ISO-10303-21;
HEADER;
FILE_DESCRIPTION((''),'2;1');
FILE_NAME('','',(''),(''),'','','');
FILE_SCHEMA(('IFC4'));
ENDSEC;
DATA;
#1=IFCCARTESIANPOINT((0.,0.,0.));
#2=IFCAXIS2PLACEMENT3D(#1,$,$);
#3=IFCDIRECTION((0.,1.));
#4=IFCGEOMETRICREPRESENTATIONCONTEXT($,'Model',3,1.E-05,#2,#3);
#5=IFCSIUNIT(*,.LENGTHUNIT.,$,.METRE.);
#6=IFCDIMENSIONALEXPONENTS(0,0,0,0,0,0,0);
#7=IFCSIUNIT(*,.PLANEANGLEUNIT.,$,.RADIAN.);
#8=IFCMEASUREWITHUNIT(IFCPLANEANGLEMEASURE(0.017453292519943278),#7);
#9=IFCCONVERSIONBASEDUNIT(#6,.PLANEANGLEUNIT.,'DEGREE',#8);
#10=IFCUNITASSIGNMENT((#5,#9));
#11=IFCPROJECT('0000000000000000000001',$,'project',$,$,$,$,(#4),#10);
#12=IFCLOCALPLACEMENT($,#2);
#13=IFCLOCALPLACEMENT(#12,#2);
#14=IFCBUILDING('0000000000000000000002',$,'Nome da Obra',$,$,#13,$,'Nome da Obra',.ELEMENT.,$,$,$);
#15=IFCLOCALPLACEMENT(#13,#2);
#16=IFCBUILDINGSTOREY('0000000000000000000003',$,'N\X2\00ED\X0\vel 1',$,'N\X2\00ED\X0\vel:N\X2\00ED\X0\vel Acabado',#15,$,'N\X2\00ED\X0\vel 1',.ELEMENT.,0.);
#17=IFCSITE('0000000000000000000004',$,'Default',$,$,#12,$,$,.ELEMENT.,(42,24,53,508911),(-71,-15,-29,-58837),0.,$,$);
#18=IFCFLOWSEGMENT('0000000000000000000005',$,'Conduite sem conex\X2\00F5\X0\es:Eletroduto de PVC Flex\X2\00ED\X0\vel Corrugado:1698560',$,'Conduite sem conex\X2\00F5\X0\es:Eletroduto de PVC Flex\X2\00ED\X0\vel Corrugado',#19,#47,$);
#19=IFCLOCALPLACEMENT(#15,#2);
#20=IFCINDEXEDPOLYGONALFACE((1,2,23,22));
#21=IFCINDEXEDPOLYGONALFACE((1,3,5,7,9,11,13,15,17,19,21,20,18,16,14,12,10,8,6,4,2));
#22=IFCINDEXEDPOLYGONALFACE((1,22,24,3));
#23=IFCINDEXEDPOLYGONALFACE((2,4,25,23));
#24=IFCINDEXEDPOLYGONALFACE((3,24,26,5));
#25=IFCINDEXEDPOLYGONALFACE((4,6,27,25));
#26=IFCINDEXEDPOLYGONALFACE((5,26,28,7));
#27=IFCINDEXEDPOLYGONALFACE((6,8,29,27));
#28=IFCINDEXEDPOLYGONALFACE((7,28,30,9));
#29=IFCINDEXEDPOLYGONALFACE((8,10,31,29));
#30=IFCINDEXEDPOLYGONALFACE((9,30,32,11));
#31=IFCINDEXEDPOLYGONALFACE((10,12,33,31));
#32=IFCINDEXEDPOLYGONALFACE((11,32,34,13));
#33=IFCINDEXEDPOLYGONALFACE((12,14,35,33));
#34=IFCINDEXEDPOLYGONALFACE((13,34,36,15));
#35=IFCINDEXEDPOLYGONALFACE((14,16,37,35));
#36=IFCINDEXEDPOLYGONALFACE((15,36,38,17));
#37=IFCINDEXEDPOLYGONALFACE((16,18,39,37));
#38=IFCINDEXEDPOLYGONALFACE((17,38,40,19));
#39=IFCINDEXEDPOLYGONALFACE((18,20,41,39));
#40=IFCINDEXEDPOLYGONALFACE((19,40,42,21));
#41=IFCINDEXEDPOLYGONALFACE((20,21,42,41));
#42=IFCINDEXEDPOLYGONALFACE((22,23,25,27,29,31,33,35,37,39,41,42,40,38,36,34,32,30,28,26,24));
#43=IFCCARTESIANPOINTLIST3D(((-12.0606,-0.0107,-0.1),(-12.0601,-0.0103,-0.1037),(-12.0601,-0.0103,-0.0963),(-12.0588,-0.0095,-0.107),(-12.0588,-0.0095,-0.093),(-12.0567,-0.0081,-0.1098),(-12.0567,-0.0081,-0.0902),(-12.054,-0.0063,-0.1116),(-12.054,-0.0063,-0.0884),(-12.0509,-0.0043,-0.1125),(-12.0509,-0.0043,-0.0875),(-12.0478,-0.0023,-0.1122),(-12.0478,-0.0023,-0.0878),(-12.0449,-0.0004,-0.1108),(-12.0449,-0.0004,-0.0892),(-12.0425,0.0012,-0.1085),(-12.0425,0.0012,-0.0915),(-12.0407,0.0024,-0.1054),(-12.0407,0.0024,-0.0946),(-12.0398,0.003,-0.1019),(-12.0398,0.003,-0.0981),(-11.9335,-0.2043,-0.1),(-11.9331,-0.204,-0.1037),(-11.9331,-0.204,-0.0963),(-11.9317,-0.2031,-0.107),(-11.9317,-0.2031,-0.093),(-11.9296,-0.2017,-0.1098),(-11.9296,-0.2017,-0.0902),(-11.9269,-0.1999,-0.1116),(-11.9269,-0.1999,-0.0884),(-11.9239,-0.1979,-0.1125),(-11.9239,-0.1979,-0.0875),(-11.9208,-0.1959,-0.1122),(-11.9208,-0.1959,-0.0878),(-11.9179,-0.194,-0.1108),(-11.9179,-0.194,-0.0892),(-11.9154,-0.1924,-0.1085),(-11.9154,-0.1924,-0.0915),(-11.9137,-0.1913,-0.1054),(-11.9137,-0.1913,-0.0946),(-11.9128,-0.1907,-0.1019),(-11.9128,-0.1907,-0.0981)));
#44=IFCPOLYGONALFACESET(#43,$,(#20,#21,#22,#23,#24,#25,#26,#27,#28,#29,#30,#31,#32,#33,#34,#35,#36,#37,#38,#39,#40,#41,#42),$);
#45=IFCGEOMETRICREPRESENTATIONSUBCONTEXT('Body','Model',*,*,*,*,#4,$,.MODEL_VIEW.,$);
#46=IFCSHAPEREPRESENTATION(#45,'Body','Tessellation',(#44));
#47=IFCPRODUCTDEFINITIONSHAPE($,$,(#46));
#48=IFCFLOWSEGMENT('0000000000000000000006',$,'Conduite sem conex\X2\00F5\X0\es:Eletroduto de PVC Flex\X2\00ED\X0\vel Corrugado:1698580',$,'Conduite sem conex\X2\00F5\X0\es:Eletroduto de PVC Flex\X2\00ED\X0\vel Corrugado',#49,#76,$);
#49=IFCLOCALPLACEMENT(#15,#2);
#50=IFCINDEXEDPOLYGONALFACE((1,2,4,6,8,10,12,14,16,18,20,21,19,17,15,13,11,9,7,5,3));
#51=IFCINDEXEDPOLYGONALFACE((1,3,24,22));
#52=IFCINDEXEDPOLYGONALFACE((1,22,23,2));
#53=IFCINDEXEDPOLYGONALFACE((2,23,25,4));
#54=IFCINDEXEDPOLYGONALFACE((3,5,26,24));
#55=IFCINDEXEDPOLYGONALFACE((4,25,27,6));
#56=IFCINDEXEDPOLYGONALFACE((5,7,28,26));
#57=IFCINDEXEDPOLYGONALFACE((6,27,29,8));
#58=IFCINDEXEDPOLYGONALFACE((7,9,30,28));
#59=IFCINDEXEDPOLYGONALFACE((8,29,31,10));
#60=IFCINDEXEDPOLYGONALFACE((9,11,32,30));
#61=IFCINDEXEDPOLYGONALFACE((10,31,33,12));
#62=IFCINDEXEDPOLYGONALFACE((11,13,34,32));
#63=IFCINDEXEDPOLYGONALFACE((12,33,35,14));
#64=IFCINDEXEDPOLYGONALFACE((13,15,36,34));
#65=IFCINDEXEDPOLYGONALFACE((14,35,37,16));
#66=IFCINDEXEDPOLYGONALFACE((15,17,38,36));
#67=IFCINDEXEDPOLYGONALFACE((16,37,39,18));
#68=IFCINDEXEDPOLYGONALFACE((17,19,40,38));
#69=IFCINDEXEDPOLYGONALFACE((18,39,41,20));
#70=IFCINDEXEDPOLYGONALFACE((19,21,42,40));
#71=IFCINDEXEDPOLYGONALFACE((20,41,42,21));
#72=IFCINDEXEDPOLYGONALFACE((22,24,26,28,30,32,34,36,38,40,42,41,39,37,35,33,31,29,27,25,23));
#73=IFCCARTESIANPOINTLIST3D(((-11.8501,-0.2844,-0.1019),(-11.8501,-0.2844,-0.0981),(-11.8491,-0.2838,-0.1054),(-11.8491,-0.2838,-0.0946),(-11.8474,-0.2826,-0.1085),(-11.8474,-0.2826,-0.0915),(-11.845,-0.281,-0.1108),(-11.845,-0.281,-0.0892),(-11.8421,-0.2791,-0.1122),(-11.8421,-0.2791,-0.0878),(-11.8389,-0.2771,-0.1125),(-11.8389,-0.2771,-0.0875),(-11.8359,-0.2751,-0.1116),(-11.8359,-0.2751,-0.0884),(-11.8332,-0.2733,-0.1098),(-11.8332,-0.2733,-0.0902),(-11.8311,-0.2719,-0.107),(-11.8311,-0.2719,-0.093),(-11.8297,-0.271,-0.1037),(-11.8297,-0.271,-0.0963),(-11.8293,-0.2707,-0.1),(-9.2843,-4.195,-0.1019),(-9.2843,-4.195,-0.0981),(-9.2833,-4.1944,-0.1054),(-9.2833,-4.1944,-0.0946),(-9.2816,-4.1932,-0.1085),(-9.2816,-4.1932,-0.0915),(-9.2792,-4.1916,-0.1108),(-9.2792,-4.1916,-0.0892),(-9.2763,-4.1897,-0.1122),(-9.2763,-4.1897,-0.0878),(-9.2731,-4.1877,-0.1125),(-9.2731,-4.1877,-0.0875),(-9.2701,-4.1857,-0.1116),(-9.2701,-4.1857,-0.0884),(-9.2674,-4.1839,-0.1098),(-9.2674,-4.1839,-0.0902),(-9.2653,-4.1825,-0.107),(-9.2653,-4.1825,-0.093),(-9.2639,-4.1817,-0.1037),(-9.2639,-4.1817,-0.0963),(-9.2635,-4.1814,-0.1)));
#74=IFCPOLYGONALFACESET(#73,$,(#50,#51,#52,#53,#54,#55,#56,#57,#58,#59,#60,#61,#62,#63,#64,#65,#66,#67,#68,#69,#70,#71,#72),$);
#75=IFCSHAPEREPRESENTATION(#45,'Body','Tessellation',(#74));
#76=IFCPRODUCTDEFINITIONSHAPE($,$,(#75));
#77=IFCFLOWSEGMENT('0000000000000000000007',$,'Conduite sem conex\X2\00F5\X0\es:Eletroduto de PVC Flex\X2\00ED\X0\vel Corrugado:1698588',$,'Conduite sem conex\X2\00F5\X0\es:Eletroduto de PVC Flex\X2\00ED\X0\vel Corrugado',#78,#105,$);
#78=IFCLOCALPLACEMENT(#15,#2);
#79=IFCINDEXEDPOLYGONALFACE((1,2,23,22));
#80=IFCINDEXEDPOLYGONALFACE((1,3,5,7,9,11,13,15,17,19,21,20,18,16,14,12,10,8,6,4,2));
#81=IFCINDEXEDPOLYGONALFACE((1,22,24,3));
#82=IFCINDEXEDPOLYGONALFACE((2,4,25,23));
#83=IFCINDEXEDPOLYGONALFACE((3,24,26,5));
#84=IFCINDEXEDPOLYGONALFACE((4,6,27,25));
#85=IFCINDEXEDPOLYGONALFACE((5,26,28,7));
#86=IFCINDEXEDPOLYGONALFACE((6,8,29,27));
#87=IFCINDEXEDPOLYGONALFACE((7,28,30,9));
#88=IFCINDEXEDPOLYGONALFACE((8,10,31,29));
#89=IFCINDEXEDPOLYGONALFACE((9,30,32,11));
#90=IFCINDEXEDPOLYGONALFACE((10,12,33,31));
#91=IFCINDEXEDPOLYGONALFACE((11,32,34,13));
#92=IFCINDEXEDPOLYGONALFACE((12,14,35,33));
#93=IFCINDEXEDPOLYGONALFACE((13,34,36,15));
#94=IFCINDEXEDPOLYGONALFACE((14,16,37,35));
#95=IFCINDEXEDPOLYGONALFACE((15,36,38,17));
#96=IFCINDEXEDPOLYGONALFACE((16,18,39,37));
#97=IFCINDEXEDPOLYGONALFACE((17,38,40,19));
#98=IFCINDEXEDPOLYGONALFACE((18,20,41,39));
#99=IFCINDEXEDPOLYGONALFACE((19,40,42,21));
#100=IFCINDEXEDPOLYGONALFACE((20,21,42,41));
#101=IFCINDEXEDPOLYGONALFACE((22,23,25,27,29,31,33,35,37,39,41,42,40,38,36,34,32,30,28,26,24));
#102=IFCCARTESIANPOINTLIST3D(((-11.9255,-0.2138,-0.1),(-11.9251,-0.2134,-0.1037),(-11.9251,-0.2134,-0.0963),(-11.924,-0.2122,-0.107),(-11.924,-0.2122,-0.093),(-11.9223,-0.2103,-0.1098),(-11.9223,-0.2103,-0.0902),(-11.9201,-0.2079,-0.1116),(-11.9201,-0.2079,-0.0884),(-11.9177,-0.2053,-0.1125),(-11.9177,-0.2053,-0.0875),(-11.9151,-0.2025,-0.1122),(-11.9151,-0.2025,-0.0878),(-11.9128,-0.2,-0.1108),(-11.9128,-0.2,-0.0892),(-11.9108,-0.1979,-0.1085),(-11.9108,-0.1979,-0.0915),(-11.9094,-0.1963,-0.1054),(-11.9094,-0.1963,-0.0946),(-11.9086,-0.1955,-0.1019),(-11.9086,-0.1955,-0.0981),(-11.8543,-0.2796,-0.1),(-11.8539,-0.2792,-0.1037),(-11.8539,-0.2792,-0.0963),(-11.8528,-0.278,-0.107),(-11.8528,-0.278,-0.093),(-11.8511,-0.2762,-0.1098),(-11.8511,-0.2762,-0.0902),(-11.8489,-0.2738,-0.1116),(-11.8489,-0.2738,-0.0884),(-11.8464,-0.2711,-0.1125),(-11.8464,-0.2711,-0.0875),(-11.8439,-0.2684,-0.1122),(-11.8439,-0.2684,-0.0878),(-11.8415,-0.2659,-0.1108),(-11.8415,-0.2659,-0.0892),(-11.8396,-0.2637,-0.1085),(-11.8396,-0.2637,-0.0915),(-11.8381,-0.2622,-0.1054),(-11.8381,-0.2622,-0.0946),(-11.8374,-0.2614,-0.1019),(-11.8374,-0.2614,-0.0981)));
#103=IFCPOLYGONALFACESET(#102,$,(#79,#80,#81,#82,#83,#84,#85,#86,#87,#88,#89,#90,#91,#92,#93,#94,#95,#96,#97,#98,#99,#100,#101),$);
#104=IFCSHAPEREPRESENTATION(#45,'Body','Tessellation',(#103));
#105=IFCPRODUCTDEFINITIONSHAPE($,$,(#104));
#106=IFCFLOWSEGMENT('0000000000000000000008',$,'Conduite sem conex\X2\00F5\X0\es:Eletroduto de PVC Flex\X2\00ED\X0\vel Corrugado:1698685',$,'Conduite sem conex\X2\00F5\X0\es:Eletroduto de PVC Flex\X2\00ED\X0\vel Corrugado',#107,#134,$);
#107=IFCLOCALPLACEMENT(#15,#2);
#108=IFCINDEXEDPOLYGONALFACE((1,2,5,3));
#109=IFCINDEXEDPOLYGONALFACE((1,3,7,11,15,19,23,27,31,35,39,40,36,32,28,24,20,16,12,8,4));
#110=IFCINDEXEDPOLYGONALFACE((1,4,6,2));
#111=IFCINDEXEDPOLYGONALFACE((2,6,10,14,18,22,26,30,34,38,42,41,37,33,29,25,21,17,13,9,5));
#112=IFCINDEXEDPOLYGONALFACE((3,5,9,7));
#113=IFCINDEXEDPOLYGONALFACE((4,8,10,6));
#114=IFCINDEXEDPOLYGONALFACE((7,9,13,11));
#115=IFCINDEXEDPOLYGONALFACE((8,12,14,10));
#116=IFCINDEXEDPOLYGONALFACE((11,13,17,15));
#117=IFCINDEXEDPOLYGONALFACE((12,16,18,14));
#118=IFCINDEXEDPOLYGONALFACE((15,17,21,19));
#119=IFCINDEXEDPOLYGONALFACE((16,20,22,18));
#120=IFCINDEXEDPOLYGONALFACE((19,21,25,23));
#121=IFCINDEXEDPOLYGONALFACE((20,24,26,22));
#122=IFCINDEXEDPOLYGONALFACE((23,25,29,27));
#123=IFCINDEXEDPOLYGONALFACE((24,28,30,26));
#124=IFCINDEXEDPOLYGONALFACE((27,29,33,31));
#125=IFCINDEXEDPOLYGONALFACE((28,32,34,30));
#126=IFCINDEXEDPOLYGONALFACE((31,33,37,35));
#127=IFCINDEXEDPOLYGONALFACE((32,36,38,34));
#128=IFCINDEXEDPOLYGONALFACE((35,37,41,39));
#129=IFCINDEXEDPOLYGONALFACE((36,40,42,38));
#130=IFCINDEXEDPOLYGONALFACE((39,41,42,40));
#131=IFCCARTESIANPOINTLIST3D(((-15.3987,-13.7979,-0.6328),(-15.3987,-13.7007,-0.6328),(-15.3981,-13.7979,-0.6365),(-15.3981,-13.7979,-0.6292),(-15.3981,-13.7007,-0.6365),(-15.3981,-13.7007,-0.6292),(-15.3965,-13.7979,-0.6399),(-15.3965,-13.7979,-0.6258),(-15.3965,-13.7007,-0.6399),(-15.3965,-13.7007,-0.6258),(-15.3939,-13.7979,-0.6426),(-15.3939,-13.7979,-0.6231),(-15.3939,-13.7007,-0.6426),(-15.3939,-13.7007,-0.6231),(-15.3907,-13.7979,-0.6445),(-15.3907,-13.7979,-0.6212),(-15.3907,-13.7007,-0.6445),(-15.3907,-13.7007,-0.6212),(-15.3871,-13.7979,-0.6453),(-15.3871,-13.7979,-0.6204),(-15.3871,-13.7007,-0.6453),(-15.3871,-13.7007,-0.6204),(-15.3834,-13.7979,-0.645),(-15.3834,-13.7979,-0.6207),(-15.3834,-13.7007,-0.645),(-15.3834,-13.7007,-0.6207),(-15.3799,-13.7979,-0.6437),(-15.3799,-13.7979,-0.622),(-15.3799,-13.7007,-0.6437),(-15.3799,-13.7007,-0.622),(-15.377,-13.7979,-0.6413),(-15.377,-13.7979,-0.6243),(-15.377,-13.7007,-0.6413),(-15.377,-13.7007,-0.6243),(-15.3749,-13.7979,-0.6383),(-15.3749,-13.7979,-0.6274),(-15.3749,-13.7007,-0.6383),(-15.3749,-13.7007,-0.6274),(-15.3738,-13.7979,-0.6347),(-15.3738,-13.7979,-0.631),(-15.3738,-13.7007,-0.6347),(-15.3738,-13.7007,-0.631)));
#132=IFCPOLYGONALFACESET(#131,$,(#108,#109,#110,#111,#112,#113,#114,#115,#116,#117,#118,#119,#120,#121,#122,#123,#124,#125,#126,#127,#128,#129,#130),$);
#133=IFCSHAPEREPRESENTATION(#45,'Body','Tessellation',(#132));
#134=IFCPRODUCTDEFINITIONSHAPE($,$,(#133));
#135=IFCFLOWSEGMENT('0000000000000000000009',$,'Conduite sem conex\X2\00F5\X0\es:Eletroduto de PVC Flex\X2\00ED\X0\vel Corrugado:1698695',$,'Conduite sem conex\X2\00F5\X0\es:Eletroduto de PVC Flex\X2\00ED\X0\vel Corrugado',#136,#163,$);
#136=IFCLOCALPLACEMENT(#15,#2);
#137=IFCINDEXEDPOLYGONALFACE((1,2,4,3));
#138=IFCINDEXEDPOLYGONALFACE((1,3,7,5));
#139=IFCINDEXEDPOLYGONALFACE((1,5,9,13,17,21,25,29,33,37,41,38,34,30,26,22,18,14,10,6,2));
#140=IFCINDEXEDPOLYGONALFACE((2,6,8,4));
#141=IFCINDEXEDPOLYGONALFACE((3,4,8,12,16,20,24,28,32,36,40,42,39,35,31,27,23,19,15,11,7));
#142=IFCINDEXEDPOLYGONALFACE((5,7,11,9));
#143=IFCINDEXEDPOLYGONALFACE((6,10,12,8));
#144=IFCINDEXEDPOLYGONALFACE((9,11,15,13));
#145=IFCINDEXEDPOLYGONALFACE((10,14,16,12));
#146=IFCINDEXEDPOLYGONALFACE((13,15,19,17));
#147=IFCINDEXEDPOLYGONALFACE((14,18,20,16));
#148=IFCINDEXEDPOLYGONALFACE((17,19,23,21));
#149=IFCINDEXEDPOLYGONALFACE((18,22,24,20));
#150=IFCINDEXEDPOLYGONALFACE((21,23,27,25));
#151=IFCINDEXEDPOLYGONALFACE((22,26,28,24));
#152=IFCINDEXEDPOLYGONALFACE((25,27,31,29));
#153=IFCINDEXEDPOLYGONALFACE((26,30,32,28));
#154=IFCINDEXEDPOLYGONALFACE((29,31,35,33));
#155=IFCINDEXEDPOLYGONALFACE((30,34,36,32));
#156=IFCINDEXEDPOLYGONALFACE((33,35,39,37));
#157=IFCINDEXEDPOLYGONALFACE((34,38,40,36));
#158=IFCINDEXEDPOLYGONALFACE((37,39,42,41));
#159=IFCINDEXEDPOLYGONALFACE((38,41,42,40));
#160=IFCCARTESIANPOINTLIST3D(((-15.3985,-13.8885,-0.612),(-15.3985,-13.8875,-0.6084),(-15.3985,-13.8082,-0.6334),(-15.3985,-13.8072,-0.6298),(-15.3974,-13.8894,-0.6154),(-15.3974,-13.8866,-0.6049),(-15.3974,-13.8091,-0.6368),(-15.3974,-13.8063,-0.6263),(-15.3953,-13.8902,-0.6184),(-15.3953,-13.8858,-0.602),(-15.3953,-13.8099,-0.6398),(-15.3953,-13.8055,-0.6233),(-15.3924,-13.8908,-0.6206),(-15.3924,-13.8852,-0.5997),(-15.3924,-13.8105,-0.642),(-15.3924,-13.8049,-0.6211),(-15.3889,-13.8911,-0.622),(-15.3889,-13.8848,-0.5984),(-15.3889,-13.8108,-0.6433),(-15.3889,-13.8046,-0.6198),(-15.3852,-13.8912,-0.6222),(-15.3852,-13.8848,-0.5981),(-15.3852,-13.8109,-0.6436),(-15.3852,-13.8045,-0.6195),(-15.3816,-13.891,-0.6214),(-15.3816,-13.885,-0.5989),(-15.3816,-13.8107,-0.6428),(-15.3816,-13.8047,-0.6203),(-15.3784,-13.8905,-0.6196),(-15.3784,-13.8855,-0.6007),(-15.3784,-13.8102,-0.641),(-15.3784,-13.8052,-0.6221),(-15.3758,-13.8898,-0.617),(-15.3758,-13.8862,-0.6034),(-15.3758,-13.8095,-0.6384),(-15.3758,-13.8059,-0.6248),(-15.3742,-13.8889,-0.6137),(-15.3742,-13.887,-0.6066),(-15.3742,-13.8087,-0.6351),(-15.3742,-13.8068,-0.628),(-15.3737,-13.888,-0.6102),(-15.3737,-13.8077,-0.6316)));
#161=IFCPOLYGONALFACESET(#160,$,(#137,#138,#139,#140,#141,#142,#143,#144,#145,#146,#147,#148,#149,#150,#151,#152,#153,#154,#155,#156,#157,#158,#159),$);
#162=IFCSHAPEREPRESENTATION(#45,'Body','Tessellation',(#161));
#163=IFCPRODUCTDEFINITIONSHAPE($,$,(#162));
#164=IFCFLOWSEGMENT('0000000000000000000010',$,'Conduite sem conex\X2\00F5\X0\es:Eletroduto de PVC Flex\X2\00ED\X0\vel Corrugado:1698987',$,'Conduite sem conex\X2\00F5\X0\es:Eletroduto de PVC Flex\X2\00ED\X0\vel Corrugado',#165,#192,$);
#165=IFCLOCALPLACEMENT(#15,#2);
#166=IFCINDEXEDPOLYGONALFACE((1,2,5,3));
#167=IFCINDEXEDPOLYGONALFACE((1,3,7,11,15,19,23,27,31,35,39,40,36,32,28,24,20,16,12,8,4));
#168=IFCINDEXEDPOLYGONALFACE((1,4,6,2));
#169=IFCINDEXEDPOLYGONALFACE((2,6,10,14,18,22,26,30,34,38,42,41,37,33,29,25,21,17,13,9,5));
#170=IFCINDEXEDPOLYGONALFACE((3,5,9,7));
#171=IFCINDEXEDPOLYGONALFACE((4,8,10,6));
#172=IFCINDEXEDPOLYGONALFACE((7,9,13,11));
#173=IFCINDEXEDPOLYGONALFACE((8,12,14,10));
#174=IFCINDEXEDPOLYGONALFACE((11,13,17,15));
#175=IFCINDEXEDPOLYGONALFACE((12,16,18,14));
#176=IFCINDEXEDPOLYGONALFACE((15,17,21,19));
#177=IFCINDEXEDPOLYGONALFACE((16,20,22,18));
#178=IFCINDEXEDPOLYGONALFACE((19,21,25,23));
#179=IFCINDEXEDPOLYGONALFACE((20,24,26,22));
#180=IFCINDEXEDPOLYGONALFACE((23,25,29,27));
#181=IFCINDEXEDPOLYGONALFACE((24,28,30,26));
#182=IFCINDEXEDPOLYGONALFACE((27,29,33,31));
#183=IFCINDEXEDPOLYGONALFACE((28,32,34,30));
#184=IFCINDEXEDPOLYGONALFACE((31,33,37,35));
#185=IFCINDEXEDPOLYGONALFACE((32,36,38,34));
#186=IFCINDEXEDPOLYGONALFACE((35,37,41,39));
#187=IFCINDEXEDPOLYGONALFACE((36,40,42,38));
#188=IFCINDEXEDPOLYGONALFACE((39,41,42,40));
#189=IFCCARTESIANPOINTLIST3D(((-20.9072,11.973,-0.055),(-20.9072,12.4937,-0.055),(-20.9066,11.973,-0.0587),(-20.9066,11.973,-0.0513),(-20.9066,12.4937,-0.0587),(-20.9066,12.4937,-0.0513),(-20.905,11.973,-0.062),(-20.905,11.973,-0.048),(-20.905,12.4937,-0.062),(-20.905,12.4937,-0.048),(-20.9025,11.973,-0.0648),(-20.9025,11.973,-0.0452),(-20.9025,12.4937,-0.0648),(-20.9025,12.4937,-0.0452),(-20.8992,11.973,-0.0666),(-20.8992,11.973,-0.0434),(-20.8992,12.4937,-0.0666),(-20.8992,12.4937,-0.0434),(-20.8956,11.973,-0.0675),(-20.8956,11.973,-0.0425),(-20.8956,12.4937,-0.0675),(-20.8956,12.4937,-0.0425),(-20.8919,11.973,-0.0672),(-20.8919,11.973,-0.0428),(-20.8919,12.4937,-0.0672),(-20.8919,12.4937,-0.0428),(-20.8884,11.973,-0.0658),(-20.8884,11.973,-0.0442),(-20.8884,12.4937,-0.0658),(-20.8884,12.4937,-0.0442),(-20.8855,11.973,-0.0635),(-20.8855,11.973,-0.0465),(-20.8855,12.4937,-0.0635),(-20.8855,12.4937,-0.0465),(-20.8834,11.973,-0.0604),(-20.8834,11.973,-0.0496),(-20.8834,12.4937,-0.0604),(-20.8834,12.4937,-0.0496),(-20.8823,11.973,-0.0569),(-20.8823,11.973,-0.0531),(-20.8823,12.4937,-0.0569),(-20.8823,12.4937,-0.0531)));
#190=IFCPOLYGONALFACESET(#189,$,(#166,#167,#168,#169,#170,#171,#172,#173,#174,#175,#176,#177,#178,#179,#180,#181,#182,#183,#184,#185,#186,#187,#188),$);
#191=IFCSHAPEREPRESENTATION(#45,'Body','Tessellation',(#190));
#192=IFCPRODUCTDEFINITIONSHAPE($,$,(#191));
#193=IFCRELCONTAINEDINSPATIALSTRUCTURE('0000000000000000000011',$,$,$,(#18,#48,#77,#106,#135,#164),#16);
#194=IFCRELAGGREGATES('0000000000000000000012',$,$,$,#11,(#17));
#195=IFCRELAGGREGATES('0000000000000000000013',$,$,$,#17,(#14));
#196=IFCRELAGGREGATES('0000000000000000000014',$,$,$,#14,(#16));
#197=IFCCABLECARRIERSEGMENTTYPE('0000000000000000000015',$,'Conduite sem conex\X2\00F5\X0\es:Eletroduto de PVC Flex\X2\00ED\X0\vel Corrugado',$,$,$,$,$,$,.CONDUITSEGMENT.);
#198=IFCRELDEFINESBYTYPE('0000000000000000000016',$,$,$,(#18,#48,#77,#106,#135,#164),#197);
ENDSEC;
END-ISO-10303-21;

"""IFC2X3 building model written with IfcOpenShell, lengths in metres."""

from ifc_helpers import new_model, entity, si_unit, converted_unit, direction, frame, frame_2d, origin, place, context, subcontext, project, spatial, circle, extrude, type_object, element, save


model = new_model("IFC2X3")

# Units and contexts
model_context = context("Model", 3, precision=1e-05, world=origin(), true_north=direction((0.0, 1.0)))
body_context = subcontext(model_context, "Body", "Model", "MODEL_VIEW")
ifc_project = project(units=[si_unit("LENGTHUNIT", "METRE"), converted_unit("PLANEANGLEUNIT", "DEGREE", entity("IfcPlaneAngleMeasure", 0.017453292519943278), si_unit("PLANEANGLEUNIT", "RADIAN"), dimensions=[0, 0, 0, 0, 0, 0, 0])], contexts=[model_context])

# Site, building, storey
site_placement = place(None, origin())
site = spatial("IfcSite", under=ifc_project, at=site_placement, Name="Default", CompositionType="ELEMENT", RefLatitude=(42, 24, 53, 508911), RefLongitude=(-71, -15, -29, -58837), RefElevation=0.0)
building_placement = place(site_placement, origin())
building = spatial("IfcBuilding", under=site, at=building_placement, Name="Nome da Obra", LongName="Nome da Obra", CompositionType="ELEMENT")
storey_placement = place(building_placement, origin())
storey = spatial("IfcBuildingStorey", under=building, at=storey_placement, Name="Nível 1", ObjectType="Nível:Nível Acabado", LongName="Nível 1", CompositionType="ELEMENT", Elevation=0.0)

# Flow segments
cable_carrier_segment_type = type_object("IfcCableCarrierSegmentType", Name="Conduite sem conexões:Eletroduto de PVC Flexível Corrugado", PredefinedType="CONDUITSEGMENT")
flow_segment_1_placement = place(storey_placement, origin())
element("IfcFlowSegment", 1, at=flow_segment_1_placement, inside=storey, type_object=cable_carrier_segment_type, Name="Conduite sem conexões:Eletroduto de PVC Flexível Corrugado:1698560", ObjectType="Conduite sem conexões:Eletroduto de PVC Flexível Corrugado", context=body_context, shape_type="SweptSolid", body=[
    extrude(circle(Radius=0.0125, at=frame_2d((0.0, 0.0), x_axis=(1.0, 0.0))), frame((-11.9231, -0.1974, -0.1), z_axis=(-0.548576, 0.836101, 0.0), x_axis=(-0.836101, -0.548576, 0.0)), (0.0, 0.0, 1.0), 0.2316),
])
flow_segment_2_placement = place(storey_placement, origin())
element("IfcFlowSegment", 2, at=flow_segment_2_placement, inside=storey, type_object=cable_carrier_segment_type, Name="Conduite sem conexões:Eletroduto de PVC Flexível Corrugado:1698580", ObjectType="Conduite sem conexões:Eletroduto de PVC Flexível Corrugado", context=body_context, shape_type="SweptSolid", body=[
    extrude(circle(Radius=0.0125, at=frame_2d((0.0, 0.0), x_axis=(1.0, 0.0))), frame((-11.8397, -0.2776, -0.1), z_axis=(0.548576, -0.836101, 0.0), x_axis=(0.836101, 0.548576, 0.0)), (0.0, 0.0, 1.0), 4.6772),
])
flow_segment_3_placement = place(storey_placement, origin())
element("IfcFlowSegment", 3, at=flow_segment_3_placement, inside=storey, type_object=cable_carrier_segment_type, Name="Conduite sem conexões:Eletroduto de PVC Flexível Corrugado:1698588", ObjectType="Conduite sem conexões:Eletroduto de PVC Flexível Corrugado", context=body_context, shape_type="SweptSolid", body=[
    extrude(circle(Radius=0.0125, at=frame_2d((0.0, 0.0), x_axis=(1.0, 0.0))), frame((-11.8458, -0.2704, -0.1), z_axis=(-0.734349, 0.678772, 0.0), x_axis=(-0.678772, -0.734349, 0.0)), (0.0, 0.0, 1.0), 0.097),
])
flow_segment_4_placement = place(storey_placement, origin())
element("IfcFlowSegment", 4, at=flow_segment_4_placement, inside=storey, type_object=cable_carrier_segment_type, Name="Conduite sem conexões:Eletroduto de PVC Flexível Corrugado:1698685", ObjectType="Conduite sem conexões:Eletroduto de PVC Flexível Corrugado", context=body_context, shape_type="SweptSolid", body=[
    extrude(circle(Radius=0.0125, at=frame_2d((0.0, 0.0), x_axis=(1.0, 0.0))), frame((-15.3862, -13.7979, -0.6328), z_axis=(0.0, 1.0, 0.0), x_axis=(-1.0, 0.0, 0.0)), (0.0, 0.0, 1.0), 0.0972),
])
flow_segment_5_placement = place(storey_placement, origin())
element("IfcFlowSegment", 5, at=flow_segment_5_placement, inside=storey, type_object=cable_carrier_segment_type, Name="Conduite sem conexões:Eletroduto de PVC Flexível Corrugado:1698695", ObjectType="Conduite sem conexões:Eletroduto de PVC Flexível Corrugado", context=body_context, shape_type="SweptSolid", body=[
    extrude(circle(Radius=0.0125, at=frame_2d((0.0, 0.0), x_axis=(1.0, 0.0))), frame((-15.3862, -13.888, -0.6102), z_axis=(0.0, 0.966328, -0.257315), x_axis=(1.0, 0.0, 0.0)), (0.0, 0.0, 1.0), 0.0831),
])
flow_segment_6_placement = place(storey_placement, origin())
element("IfcFlowSegment", 6, at=flow_segment_6_placement, inside=storey, type_object=cable_carrier_segment_type, Name="Conduite sem conexões:Eletroduto de PVC Flexível Corrugado:1698987", ObjectType="Conduite sem conexões:Eletroduto de PVC Flexível Corrugado", context=body_context, shape_type="SweptSolid", body=[
    extrude(circle(Radius=0.0125, at=frame_2d((0.0, 0.0), x_axis=(1.0, 0.0))), frame((-20.8947, 11.973, -0.055), z_axis=(0.0, 1.0, 0.0), x_axis=(-1.0, 0.0, 0.0)), (0.0, 0.0, 1.0), 0.5207),
])

save(model, "model.ifc")
